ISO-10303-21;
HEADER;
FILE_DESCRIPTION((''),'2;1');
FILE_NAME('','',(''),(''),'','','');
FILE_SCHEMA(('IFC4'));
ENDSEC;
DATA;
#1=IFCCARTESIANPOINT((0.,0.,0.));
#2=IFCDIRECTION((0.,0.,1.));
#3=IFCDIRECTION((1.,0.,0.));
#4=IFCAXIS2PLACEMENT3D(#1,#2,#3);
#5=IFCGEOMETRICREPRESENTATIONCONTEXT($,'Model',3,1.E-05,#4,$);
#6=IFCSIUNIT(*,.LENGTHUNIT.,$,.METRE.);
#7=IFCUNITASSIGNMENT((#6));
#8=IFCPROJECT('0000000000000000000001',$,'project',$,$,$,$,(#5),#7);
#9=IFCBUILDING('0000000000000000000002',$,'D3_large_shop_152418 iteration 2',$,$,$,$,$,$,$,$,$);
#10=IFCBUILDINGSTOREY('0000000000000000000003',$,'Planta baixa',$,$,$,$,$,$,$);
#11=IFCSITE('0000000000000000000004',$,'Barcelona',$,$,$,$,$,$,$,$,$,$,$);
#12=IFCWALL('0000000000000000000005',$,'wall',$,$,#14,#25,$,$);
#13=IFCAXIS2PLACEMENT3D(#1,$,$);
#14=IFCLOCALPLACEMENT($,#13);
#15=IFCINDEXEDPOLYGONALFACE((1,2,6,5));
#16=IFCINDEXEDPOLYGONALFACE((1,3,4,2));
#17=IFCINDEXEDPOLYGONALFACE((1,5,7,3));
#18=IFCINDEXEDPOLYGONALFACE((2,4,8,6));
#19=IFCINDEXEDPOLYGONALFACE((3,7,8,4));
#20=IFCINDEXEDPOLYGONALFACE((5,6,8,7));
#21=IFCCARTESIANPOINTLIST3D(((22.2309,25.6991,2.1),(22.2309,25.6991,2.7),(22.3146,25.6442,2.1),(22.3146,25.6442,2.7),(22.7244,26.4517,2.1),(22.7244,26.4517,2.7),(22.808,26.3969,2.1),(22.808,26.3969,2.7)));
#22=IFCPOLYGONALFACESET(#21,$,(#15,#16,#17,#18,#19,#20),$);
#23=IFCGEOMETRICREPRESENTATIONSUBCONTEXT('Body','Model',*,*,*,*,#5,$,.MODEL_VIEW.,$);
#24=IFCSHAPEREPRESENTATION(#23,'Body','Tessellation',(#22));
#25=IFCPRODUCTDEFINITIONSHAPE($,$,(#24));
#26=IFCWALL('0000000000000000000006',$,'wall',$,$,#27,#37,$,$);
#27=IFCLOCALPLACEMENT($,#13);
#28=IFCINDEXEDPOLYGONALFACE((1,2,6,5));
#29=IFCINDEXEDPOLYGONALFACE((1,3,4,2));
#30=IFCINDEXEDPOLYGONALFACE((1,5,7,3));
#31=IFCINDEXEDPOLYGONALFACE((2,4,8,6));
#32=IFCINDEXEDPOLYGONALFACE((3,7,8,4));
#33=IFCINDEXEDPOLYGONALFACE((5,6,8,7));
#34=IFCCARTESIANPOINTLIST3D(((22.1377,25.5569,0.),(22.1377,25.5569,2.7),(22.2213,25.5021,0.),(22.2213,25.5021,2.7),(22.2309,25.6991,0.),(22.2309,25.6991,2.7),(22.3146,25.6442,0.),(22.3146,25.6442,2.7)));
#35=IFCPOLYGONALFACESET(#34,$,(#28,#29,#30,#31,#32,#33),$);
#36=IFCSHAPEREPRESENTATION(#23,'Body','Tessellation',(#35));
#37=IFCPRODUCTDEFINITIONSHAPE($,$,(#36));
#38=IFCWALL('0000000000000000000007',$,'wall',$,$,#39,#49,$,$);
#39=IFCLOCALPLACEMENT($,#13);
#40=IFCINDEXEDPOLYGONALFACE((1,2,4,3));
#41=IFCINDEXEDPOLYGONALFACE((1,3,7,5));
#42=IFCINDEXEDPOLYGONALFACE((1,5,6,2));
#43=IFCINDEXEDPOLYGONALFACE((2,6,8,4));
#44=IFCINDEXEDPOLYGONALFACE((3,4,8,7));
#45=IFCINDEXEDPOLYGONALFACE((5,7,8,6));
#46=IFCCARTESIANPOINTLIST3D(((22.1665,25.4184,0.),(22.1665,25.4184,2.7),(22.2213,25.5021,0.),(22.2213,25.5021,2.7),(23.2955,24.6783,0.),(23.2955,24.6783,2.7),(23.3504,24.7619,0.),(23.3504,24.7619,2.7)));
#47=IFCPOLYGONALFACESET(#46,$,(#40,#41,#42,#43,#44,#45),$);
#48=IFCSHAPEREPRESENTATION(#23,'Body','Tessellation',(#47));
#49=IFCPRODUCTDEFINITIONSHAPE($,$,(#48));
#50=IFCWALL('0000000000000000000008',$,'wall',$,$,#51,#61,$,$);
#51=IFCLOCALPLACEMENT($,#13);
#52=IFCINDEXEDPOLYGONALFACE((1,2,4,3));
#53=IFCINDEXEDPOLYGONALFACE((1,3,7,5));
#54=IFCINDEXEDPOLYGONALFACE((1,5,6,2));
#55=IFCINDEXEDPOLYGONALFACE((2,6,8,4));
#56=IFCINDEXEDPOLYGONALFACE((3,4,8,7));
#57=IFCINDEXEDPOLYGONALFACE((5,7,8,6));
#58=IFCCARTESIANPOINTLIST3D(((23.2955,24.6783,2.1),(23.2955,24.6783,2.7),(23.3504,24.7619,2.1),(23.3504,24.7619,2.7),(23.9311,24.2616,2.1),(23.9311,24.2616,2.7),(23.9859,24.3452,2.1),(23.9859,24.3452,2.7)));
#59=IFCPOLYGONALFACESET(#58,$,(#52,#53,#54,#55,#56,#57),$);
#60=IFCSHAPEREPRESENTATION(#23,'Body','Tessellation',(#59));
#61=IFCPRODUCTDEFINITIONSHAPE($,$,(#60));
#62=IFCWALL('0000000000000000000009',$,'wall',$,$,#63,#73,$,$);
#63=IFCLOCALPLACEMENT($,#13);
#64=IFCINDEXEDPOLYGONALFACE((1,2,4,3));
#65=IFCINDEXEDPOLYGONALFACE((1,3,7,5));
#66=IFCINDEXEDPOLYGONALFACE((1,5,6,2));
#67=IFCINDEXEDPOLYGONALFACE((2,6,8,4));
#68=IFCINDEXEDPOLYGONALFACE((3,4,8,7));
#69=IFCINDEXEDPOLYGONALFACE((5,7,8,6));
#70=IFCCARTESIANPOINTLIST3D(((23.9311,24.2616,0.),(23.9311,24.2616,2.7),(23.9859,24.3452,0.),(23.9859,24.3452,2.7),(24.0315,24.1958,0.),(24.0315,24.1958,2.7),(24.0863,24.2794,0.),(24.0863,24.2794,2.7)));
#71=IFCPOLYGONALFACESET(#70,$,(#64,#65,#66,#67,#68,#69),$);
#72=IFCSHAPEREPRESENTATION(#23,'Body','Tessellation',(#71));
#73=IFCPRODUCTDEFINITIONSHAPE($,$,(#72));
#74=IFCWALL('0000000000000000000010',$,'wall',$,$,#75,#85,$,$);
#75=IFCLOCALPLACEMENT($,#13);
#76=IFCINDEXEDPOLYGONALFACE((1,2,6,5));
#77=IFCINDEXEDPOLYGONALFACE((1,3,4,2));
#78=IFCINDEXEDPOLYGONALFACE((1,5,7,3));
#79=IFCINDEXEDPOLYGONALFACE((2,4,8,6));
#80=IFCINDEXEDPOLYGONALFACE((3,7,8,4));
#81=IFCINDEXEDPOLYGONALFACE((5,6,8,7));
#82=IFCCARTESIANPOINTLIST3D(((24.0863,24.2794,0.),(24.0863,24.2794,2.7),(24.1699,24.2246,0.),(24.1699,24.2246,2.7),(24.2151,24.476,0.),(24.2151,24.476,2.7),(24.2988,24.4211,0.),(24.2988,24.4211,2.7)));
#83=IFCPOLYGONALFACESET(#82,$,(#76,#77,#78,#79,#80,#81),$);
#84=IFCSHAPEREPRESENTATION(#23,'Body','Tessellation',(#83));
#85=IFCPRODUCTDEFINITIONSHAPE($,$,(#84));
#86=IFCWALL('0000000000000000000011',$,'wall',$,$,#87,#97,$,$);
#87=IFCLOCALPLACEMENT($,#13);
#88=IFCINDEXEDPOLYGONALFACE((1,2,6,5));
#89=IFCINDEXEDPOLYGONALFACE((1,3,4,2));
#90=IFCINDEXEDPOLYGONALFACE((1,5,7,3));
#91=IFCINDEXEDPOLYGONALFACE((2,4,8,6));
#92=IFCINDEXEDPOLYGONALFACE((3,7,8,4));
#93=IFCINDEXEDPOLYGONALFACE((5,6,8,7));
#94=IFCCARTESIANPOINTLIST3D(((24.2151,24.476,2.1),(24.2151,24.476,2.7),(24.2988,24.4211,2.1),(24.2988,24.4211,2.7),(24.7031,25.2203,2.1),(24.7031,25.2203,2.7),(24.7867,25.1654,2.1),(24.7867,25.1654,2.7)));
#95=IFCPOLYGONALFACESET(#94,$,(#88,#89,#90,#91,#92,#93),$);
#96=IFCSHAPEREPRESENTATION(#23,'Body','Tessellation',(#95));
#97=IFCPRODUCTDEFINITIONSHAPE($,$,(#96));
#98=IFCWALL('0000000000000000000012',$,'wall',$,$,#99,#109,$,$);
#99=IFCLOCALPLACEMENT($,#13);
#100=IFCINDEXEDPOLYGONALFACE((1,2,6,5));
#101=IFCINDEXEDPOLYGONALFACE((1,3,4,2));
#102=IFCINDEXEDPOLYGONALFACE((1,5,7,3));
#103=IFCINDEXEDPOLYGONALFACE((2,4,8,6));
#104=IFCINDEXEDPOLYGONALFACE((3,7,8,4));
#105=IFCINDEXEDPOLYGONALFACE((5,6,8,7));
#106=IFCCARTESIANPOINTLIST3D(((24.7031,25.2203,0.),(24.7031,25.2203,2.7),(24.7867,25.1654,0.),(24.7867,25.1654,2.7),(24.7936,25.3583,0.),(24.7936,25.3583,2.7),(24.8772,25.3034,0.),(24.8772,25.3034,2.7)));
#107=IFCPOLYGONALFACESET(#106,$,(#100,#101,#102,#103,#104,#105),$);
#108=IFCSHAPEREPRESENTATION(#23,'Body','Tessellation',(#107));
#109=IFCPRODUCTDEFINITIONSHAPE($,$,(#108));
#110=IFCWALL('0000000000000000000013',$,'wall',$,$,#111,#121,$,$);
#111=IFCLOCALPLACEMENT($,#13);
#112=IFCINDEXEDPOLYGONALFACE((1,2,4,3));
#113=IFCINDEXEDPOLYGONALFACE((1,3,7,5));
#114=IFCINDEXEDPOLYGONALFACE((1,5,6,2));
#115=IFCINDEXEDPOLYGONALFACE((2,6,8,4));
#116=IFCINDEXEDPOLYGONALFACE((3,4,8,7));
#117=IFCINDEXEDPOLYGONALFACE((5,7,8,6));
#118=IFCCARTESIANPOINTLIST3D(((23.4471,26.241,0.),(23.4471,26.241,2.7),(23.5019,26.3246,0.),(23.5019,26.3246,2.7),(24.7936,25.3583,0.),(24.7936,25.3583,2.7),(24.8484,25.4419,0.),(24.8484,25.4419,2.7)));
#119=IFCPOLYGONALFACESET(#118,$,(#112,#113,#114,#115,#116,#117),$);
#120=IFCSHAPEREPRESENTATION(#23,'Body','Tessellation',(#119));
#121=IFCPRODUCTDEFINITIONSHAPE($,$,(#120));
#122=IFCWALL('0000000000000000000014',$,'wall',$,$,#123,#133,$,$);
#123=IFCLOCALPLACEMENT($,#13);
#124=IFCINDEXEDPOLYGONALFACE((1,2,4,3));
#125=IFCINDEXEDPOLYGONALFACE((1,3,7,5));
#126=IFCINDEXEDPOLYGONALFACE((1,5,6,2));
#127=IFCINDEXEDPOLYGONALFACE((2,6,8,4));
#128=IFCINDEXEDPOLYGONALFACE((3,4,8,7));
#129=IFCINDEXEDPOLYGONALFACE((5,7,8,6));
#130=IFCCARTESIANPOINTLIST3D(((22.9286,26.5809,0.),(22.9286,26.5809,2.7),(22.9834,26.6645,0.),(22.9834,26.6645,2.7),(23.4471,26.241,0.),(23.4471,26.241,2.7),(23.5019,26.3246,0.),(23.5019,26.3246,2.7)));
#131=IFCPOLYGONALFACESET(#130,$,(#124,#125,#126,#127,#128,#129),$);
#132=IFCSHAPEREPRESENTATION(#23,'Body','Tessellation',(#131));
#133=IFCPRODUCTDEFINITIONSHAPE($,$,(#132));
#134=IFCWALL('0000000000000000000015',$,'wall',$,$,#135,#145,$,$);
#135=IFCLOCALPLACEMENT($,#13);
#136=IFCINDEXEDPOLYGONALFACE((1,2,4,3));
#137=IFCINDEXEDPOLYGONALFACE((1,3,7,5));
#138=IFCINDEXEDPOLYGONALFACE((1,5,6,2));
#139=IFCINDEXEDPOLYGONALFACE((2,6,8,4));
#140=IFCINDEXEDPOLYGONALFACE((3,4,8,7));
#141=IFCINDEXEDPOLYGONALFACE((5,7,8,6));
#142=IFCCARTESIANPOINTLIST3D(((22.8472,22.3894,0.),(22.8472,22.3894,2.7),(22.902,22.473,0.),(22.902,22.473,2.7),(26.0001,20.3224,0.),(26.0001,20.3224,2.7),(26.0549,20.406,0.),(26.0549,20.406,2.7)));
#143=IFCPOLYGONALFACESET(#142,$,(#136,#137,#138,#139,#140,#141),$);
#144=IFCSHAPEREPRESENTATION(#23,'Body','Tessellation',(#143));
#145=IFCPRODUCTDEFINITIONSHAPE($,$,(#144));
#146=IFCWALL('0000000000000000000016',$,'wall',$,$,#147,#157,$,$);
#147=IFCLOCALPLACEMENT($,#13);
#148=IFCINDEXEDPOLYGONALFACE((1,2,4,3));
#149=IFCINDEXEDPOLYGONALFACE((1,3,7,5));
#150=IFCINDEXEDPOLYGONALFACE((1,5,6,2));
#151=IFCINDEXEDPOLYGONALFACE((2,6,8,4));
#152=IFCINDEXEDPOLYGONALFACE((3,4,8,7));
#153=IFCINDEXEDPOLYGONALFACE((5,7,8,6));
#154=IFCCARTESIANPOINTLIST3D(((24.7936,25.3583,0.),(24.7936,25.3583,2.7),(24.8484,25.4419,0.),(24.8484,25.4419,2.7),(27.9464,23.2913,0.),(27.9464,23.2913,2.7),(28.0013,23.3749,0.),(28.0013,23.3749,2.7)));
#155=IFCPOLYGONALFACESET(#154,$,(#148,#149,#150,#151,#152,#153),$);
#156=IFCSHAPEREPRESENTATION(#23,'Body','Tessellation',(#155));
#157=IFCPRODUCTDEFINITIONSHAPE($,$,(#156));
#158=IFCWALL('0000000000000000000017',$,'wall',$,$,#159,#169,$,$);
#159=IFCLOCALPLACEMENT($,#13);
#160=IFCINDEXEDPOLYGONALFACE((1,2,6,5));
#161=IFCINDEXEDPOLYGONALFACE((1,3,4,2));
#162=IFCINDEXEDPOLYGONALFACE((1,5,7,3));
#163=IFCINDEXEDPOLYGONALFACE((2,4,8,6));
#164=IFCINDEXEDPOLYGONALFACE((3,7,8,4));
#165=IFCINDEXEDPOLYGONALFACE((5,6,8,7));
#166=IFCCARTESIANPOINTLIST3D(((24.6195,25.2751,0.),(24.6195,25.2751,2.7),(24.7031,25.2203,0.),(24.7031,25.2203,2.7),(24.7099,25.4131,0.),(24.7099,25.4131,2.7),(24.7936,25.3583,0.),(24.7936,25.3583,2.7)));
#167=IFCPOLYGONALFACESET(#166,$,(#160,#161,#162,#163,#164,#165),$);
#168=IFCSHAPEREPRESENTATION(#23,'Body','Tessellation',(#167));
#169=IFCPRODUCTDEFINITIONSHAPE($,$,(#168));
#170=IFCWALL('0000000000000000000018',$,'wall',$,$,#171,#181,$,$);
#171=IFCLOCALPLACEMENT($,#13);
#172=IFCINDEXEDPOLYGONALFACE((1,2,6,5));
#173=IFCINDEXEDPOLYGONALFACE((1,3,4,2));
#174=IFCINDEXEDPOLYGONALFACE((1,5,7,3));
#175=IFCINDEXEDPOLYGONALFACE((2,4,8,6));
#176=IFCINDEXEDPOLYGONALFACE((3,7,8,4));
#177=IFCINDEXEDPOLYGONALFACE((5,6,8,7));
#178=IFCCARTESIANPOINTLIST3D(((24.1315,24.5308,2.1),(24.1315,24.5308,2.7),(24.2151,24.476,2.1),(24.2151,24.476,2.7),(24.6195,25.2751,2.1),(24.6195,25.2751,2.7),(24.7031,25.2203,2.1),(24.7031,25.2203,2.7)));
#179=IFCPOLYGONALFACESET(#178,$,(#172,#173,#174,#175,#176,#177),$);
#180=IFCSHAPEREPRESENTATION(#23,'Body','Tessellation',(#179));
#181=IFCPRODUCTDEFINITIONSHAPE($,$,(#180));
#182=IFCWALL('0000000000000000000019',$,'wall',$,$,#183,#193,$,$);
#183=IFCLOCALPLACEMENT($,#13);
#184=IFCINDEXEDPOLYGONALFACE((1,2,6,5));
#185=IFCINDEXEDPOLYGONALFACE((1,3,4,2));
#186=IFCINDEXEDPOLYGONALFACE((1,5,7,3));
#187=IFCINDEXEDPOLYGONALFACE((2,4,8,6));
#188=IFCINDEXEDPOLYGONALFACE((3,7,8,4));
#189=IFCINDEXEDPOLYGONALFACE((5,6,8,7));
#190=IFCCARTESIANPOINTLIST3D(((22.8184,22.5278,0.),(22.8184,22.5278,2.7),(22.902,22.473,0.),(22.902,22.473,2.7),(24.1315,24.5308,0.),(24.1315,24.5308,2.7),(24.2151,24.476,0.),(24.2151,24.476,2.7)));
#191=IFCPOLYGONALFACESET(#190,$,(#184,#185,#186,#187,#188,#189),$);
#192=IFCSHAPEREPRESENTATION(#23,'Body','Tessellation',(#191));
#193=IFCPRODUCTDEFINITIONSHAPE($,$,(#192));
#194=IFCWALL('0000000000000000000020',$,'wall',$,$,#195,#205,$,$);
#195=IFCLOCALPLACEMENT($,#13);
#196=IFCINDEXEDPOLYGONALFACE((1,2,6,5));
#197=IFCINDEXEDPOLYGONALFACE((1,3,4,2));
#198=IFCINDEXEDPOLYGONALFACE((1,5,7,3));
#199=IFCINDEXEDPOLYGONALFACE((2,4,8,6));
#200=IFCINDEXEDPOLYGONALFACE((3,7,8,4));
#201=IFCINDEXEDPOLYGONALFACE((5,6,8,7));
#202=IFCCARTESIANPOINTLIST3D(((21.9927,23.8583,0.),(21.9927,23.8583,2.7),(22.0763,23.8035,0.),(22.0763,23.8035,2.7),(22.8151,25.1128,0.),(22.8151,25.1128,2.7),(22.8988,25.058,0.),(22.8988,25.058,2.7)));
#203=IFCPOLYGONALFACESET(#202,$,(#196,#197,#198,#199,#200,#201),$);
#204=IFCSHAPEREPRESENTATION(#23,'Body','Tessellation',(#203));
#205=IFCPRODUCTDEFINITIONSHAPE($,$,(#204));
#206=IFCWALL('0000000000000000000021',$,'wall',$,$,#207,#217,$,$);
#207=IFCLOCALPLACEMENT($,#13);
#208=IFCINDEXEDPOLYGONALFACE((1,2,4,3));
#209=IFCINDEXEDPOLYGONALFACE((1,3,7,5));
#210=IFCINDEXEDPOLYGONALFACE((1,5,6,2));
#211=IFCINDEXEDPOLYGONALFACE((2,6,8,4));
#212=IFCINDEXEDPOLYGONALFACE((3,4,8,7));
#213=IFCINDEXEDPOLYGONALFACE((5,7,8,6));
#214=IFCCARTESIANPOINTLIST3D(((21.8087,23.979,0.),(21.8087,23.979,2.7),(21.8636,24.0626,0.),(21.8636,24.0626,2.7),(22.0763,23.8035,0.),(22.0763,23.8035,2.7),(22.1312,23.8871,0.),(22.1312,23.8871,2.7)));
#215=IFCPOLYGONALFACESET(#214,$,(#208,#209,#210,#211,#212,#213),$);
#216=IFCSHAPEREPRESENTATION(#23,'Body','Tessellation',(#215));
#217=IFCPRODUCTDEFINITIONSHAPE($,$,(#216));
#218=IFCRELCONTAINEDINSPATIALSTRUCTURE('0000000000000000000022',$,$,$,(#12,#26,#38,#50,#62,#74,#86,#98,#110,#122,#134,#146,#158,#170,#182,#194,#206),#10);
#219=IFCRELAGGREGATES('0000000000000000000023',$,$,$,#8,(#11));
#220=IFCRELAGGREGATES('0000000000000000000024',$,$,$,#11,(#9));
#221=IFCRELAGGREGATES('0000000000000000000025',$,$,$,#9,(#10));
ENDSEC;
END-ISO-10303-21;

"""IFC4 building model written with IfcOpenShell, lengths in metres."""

from ifc_helpers import new_model, si_unit, frame, origin, origin_with_axes, place, context, subcontext, project, spatial, polyline, outline, extrude, element, save


model = new_model("IFC4")

# Units and contexts
model_context = context("Model", 3, precision=1e-05, world=origin_with_axes())
body_context = subcontext(model_context, "Body", "Model", "MODEL_VIEW")
ifc_project = project(units=[si_unit("LENGTHUNIT", "METRE")], contexts=[model_context])

# Site, building, storey
site = spatial("IfcSite", under=ifc_project, Name="Barcelona")
building = spatial("IfcBuilding", under=site, Name="D3_large_shop_152418 iteration 2")
storey = spatial("IfcBuildingStorey", under=building, Name="Planta baixa")

# Walls
wall_1_placement = place(None, origin_with_axes())
element("IfcWall", 1, at=wall_1_placement, inside=storey, Name="wall", context=body_context, shape_type="SweptSolid", body=[
    extrude(outline(polyline([(22.808, 26.3969), (22.3146, 25.6442), (22.2309, 25.6991), (22.7244, 26.4517), (22.808, 26.3969)])), frame((0.0, 0.0, 2.1)), (0.0, 0.0, 1.0), 0.6),
])
wall_2_placement = place(None, origin_with_axes())
element("IfcWall", 2, at=wall_2_placement, inside=storey, Name="wall", context=body_context, shape_type="SweptSolid", body=[
    extrude(outline(polyline([(22.3146, 25.6442), (22.2213, 25.5021), (22.1377, 25.5569), (22.2309, 25.6991), (22.3146, 25.6442)])), origin(), (0.0, 0.0, 1.0), 2.7),
])
wall_3_placement = place(None, origin_with_axes())
element("IfcWall", 3, at=wall_3_placement, inside=storey, Name="wall", context=body_context, shape_type="SweptSolid", body=[
    extrude(outline(polyline([(22.2213, 25.5021), (23.3504, 24.7619), (23.2955, 24.6783), (22.1665, 25.4184), (22.2213, 25.5021)])), origin(), (0.0, 0.0, 1.0), 2.7),
])
wall_4_placement = place(None, origin_with_axes())
element("IfcWall", 4, at=wall_4_placement, inside=storey, Name="wall", context=body_context, shape_type="SweptSolid", body=[
    extrude(outline(polyline([(23.3504, 24.7619), (23.9859, 24.3452), (23.9311, 24.2616), (23.2955, 24.6783), (23.3504, 24.7619)])), frame((0.0, 0.0, 2.1)), (0.0, 0.0, 1.0), 0.6),
])
wall_5_placement = place(None, origin_with_axes())
element("IfcWall", 5, at=wall_5_placement, inside=storey, Name="wall", context=body_context, shape_type="SweptSolid", body=[
    extrude(outline(polyline([(23.9859, 24.3452), (24.0863, 24.2794), (24.0315, 24.1958), (23.9311, 24.2616), (23.9859, 24.3452)])), origin(), (0.0, 0.0, 1.0), 2.7),
])
wall_6_placement = place(None, origin_with_axes())
element("IfcWall", 6, at=wall_6_placement, inside=storey, Name="wall", context=body_context, shape_type="SweptSolid", body=[
    extrude(outline(polyline([(24.0863, 24.2794), (24.2151, 24.476), (24.2988, 24.4211), (24.1699, 24.2246), (24.0863, 24.2794)])), origin(), (0.0, 0.0, 1.0), 2.7),
])
wall_7_placement = place(None, origin_with_axes())
element("IfcWall", 7, at=wall_7_placement, inside=storey, Name="wall", context=body_context, shape_type="SweptSolid", body=[
    extrude(outline(polyline([(24.2151, 24.476), (24.7031, 25.2203), (24.7867, 25.1654), (24.2988, 24.4211), (24.2151, 24.476)])), frame((0.0, 0.0, 2.1)), (0.0, 0.0, 1.0), 0.6),
])
wall_8_placement = place(None, origin_with_axes())
element("IfcWall", 8, at=wall_8_placement, inside=storey, Name="wall", context=body_context, shape_type="SweptSolid", body=[
    extrude(outline(polyline([(24.7031, 25.2203), (24.7936, 25.3583), (24.8772, 25.3034), (24.7867, 25.1654), (24.7031, 25.2203)])), origin(), (0.0, 0.0, 1.0), 2.7),
])
wall_9_placement = place(None, origin_with_axes())
element("IfcWall", 9, at=wall_9_placement, inside=storey, Name="wall", context=body_context, shape_type="SweptSolid", body=[
    extrude(outline(polyline([(24.7936, 25.3583), (23.4471, 26.241), (23.5019, 26.3246), (24.8484, 25.4419), (24.7936, 25.3583)])), origin(), (0.0, 0.0, 1.0), 2.7),
])
wall_10_placement = place(None, origin_with_axes())
element("IfcWall", 10, at=wall_10_placement, inside=storey, Name="wall", context=body_context, shape_type="SweptSolid", body=[
    extrude(outline(polyline([(23.4471, 26.241), (22.9286, 26.5809), (22.9834, 26.6645), (23.5019, 26.3246), (23.4471, 26.241)])), origin(), (0.0, 0.0, 1.0), 2.7),
])
wall_11_placement = place(None, origin_with_axes())
element("IfcWall", 11, at=wall_11_placement, inside=storey, Name="wall", context=body_context, shape_type="SweptSolid", body=[
    extrude(outline(polyline([(22.902, 22.473), (26.0549, 20.406), (26.0001, 20.3224), (22.8472, 22.3894), (22.902, 22.473)])), origin(), (0.0, 0.0, 1.0), 2.7),
])
wall_12_placement = place(None, origin_with_axes())
element("IfcWall", 12, at=wall_12_placement, inside=storey, Name="wall", context=body_context, shape_type="SweptSolid", body=[
    extrude(outline(polyline([(27.9464, 23.2913), (24.7936, 25.3583), (24.8484, 25.4419), (28.0013, 23.3749), (27.9464, 23.2913)])), origin(), (0.0, 0.0, 1.0), 2.7),
])
wall_13_placement = place(None, origin_with_axes())
element("IfcWall", 13, at=wall_13_placement, inside=storey, Name="wall", context=body_context, shape_type="SweptSolid", body=[
    extrude(outline(polyline([(24.7936, 25.3583), (24.7031, 25.2203), (24.6195, 25.2751), (24.7099, 25.4131), (24.7936, 25.3583)])), origin(), (0.0, 0.0, 1.0), 2.7),
])
wall_14_placement = place(None, origin_with_axes())
element("IfcWall", 14, at=wall_14_placement, inside=storey, Name="wall", context=body_context, shape_type="SweptSolid", body=[
    extrude(outline(polyline([(24.7031, 25.2203), (24.2151, 24.476), (24.1315, 24.5308), (24.6195, 25.2751), (24.7031, 25.2203)])), frame((0.0, 0.0, 2.1)), (0.0, 0.0, 1.0), 0.6),
])
wall_15_placement = place(None, origin_with_axes())
element("IfcWall", 15, at=wall_15_placement, inside=storey, Name="wall", context=body_context, shape_type="SweptSolid", body=[
    extrude(outline(polyline([(24.2151, 24.476), (22.902, 22.473), (22.8184, 22.5278), (24.1315, 24.5308), (24.2151, 24.476)])), origin(), (0.0, 0.0, 1.0), 2.7),
])
wall_16_placement = place(None, origin_with_axes())
element("IfcWall", 16, at=wall_16_placement, inside=storey, Name="wall", context=body_context, shape_type="SweptSolid", body=[
    extrude(outline(polyline([(22.8988, 25.058), (22.0763, 23.8035), (21.9927, 23.8583), (22.8151, 25.1128), (22.8988, 25.058)])), origin(), (0.0, 0.0, 1.0), 2.7),
])
wall_17_placement = place(None, origin_with_axes())
element("IfcWall", 17, at=wall_17_placement, inside=storey, Name="wall", context=body_context, shape_type="SweptSolid", body=[
    extrude(outline(polyline([(22.0763, 23.8035), (21.8087, 23.979), (21.8636, 24.0626), (22.1312, 23.8871), (22.0763, 23.8035)])), origin(), (0.0, 0.0, 1.0), 2.7),
])

save(model, "model.ifc")
